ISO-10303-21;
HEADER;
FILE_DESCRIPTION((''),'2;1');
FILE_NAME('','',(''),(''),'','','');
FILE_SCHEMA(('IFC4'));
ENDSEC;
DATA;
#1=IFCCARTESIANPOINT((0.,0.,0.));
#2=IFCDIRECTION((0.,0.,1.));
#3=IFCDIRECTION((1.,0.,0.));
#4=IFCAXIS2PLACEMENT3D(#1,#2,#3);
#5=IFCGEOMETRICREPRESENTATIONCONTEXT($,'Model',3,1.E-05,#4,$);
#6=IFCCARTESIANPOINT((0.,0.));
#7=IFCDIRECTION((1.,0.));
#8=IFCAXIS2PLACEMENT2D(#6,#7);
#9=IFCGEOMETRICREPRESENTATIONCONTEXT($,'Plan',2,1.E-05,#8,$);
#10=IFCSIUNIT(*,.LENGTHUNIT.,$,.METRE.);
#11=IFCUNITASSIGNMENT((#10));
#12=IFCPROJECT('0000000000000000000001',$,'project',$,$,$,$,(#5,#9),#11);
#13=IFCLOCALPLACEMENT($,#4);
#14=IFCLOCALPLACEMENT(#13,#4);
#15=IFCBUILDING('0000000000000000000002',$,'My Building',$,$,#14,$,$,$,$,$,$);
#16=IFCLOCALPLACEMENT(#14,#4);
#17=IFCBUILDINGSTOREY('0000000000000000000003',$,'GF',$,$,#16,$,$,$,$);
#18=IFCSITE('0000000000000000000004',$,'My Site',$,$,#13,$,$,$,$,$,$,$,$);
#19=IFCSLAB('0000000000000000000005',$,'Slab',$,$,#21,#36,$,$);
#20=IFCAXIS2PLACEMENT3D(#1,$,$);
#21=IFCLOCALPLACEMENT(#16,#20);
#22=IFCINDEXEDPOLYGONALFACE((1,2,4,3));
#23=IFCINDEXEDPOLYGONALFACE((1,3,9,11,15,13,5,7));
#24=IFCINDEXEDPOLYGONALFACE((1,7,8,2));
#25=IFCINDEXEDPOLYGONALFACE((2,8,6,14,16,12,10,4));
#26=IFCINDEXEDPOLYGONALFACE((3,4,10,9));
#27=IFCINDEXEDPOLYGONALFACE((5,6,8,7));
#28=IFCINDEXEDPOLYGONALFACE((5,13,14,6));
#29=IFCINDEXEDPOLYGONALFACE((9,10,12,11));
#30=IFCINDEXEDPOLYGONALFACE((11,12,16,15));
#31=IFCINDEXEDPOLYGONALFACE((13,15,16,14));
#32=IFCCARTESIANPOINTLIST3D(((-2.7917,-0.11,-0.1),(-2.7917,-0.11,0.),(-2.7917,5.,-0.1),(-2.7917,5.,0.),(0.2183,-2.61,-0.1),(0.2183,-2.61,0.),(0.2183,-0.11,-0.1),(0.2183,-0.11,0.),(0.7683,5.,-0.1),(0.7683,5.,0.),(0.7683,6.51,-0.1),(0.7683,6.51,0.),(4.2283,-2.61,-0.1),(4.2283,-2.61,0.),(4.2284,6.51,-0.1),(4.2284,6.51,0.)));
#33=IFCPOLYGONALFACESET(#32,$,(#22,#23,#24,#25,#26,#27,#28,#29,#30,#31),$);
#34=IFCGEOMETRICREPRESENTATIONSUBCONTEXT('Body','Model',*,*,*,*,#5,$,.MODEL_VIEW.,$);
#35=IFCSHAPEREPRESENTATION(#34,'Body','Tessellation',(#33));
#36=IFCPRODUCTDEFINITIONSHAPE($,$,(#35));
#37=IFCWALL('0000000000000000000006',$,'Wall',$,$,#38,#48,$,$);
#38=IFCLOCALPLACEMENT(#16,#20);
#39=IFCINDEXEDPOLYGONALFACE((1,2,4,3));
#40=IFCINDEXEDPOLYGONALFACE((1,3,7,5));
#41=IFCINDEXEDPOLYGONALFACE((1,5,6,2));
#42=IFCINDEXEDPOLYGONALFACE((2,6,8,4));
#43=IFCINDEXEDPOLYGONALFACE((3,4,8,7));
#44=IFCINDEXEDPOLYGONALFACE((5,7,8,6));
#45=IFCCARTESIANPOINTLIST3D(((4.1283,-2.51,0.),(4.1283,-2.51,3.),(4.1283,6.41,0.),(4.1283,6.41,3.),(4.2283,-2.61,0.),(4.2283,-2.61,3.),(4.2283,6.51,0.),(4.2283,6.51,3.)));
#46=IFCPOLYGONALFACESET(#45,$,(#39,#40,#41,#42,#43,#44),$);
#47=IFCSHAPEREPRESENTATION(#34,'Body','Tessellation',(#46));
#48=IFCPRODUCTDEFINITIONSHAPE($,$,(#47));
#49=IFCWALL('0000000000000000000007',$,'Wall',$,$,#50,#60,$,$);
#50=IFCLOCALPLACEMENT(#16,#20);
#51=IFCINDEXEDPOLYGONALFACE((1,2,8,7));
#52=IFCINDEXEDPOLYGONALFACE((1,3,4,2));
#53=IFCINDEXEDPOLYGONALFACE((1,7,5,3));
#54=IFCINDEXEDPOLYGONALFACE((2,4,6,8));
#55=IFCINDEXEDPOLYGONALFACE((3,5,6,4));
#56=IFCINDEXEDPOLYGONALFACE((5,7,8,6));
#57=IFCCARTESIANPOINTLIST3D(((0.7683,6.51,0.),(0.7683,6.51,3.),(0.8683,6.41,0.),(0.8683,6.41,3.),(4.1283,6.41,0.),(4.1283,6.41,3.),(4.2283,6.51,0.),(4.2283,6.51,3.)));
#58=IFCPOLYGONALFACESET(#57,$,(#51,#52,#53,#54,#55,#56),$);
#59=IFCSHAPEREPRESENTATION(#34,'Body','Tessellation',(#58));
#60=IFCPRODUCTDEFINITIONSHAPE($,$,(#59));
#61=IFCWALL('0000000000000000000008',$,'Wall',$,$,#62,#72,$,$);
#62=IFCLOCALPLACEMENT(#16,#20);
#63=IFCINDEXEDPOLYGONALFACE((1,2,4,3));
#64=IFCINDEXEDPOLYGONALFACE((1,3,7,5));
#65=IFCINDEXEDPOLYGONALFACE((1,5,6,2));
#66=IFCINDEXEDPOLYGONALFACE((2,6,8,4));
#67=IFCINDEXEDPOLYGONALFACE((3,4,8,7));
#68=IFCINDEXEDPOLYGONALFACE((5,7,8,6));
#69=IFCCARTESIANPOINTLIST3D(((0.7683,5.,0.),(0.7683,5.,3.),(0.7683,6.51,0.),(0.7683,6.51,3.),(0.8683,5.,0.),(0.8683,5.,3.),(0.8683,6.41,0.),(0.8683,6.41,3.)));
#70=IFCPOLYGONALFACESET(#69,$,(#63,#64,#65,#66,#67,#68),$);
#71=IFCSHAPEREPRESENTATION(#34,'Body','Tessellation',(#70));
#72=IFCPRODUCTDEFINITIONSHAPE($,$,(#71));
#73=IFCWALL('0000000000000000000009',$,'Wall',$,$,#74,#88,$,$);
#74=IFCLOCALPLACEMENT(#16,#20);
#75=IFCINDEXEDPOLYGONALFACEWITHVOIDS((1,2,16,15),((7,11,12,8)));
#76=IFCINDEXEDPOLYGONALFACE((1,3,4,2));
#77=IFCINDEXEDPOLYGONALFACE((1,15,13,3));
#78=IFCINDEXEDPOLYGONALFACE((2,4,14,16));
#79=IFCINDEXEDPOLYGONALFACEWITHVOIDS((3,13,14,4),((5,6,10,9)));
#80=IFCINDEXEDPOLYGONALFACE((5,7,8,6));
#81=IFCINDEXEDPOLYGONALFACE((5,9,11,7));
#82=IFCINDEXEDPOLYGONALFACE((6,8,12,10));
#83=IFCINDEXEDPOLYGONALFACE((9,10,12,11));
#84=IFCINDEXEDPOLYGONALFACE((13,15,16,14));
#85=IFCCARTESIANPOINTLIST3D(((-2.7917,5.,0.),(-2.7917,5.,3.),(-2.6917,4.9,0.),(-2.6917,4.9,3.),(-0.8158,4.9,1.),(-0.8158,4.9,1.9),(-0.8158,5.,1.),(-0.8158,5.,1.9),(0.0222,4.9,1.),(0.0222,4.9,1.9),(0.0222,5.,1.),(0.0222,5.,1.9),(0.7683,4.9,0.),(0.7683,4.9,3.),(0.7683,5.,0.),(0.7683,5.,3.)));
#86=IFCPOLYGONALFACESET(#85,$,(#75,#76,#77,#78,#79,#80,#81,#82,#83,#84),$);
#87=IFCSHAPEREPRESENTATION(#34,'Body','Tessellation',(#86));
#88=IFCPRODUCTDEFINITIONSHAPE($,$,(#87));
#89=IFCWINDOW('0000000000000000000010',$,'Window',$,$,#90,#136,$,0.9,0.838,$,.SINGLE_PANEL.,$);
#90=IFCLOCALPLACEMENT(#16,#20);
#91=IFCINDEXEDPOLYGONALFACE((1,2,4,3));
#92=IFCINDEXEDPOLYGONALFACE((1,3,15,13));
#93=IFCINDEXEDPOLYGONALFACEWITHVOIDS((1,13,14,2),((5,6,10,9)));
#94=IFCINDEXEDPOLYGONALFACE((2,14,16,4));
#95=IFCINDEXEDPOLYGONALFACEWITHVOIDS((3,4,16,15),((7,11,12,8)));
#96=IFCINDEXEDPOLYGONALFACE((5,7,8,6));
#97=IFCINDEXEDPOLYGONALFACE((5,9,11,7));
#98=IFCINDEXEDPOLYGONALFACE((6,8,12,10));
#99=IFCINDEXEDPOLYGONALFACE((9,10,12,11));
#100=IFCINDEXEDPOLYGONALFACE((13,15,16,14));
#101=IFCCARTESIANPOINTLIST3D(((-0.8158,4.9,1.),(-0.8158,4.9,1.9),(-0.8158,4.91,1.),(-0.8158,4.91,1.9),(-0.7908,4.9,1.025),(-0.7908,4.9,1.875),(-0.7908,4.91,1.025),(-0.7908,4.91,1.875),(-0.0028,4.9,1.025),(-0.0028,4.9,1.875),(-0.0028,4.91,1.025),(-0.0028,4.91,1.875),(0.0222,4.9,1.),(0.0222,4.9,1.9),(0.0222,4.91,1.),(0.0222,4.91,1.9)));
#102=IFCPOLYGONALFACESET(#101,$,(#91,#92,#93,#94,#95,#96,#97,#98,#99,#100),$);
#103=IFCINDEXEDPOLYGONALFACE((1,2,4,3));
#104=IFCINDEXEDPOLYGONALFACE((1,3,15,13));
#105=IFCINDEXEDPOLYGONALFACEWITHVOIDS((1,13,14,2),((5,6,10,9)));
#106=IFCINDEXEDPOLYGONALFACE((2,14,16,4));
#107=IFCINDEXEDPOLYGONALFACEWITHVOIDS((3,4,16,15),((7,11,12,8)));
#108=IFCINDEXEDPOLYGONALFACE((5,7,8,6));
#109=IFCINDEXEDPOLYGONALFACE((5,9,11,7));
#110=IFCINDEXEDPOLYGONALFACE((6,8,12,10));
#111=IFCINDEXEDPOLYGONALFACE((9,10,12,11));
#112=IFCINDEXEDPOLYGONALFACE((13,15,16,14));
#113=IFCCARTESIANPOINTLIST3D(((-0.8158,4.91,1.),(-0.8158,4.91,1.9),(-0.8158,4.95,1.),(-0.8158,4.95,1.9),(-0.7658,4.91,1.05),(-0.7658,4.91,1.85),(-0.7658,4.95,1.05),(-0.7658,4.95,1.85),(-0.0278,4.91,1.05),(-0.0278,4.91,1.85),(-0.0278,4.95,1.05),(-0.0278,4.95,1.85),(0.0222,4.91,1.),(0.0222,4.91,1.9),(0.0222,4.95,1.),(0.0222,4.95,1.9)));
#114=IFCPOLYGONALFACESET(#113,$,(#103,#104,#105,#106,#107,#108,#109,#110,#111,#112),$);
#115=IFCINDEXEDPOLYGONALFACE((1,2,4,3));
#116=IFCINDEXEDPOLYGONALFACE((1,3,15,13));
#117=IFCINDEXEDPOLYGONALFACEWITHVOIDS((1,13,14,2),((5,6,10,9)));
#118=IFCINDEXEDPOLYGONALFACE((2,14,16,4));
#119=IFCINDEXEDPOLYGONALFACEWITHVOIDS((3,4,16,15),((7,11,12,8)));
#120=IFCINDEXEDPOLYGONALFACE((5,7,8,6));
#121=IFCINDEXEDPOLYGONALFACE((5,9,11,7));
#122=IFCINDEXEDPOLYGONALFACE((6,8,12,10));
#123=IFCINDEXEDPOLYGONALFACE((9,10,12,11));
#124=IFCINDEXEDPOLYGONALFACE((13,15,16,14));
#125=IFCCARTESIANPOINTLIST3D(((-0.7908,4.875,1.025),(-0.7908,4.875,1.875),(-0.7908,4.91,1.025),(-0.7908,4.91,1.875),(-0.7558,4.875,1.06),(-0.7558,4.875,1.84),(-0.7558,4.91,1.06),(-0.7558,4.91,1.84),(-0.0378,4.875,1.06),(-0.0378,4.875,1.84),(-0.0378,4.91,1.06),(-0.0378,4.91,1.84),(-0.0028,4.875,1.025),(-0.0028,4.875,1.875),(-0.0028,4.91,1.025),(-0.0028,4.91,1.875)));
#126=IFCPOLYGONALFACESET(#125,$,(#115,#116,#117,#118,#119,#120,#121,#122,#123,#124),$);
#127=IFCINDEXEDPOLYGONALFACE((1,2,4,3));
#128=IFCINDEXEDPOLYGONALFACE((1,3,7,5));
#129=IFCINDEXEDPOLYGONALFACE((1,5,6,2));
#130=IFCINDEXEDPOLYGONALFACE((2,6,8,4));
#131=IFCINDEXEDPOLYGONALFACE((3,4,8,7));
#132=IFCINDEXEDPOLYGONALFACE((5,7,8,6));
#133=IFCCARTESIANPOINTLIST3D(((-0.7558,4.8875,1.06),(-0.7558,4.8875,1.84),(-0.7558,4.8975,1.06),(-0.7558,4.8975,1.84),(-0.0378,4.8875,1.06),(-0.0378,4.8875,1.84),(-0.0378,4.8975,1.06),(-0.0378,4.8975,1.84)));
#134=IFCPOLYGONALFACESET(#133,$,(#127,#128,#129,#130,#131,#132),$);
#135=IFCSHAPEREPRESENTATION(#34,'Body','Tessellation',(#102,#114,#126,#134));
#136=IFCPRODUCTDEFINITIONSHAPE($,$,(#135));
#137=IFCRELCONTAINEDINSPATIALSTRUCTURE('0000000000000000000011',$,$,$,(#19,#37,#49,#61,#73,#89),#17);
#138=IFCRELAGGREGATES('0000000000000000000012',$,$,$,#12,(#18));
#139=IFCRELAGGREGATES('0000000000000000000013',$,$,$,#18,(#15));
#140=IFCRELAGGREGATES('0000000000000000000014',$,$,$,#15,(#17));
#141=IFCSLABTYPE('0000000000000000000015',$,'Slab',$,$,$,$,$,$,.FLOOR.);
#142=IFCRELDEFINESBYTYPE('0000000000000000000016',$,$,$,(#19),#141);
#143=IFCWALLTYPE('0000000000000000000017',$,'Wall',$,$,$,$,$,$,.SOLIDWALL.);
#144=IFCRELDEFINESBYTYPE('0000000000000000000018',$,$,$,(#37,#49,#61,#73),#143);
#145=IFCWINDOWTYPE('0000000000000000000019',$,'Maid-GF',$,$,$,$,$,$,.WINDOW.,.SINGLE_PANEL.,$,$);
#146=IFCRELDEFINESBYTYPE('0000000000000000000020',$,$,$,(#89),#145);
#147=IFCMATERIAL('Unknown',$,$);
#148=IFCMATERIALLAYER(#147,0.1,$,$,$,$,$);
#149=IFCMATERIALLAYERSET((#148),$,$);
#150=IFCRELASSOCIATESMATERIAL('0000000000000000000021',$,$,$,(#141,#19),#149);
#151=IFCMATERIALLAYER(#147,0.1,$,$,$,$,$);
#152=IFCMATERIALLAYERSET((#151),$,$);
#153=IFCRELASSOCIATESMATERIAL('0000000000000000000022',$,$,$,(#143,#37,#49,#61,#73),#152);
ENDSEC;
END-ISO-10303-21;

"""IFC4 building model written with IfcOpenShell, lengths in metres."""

from ifc_helpers import new_model, entity, si_unit, frame, origin_with_axes, origin_2d_with_axis, place, context, subcontext, project, spatial, line, indexed_curve, outline, extrude, shape, source, transform, mapped, material, layer, layer_set, layer_usage, type_object, type_shapes, element, fill, save


model = new_model("IFC4")

# Units and contexts
model_context = context("Model", 3, precision=1e-05, world=origin_with_axes())
plan_context = context("Plan", 2, precision=1e-05, world=origin_2d_with_axis())
body_context_1 = subcontext(model_context, "Body", "Model", "MODEL_VIEW")
body_context_2 = subcontext(plan_context, "Body", "Plan", "PLAN_VIEW")
ifc_project = project(units=[si_unit("LENGTHUNIT", "METRE")], contexts=[model_context, plan_context])

# Site, building, storey
site_placement = place(None, origin_with_axes())
site = spatial("IfcSite", under=ifc_project, at=site_placement, Name="My Site")
building_placement = place(site_placement, origin_with_axes())
building = spatial("IfcBuilding", under=site, at=building_placement, Name="My Building")
storey_placement = place(building_placement, origin_with_axes())
storey = spatial("IfcBuildingStorey", under=building, at=storey_placement, Name="GF")

# Slab
ifc_material = material(Name="Unknown")
ifc_layer_1 = layer(ifc_material, 0.1)
ifc_layer_set_1 = layer_set([ifc_layer_1])
ifc_layer_usage_1 = layer_usage(ifc_layer_set_1, "AXIS3", "POSITIVE", -0.1)
slab_type = type_object("IfcSlabType", Name="Slab", PredefinedType="FLOOR", material=ifc_layer_set_1)
slab_placement = place(storey_placement, frame((0.2183, -2.61, 0.0), z_axis=(0.0, 0.0, 1.0), x_axis=(1.0, 0.0, 0.0)))
element("IfcSlab", 1, at=slab_placement, inside=storey, type_object=slab_type, material=ifc_layer_usage_1, Name="Slab", context=body_context_1, shape_type="SweptSolid", body=[
    extrude(outline(indexed_curve([(4.01, 0.0), (4.01, 9.12), (0.55, 9.12), (0.55, 7.61), (-3.01, 7.61), (-3.01, 2.5), (0.0, 2.5), (0.0, 0.0), (4.01, 0.0)])), frame((0.0, 0.0, -0.1), z_axis=(0.0, 0.0, 1.0), x_axis=(1.0, 0.0, 0.0)), (0.0, 0.0, 1.0), 0.1),
])

# Shared definitions
ifc_layer_2 = layer(ifc_material, 0.1)
ifc_layer_set_2 = layer_set([ifc_layer_2])
wall_type = type_object("IfcWallType", Name="Wall", PredefinedType="SOLIDWALL", material=ifc_layer_set_2)

# Walls
ifc_layer_usage_2 = layer_usage(ifc_layer_set_2, "AXIS2", "POSITIVE", 0.0)
wall_1_placement = place(storey_placement, frame((4.2283, -2.61, 0.0), z_axis=(0.0, 0.0, 1.0), x_axis=(0.0, 1.0, 0.0)))
element("IfcWall", 2, at=wall_1_placement, inside=storey, type_object=wall_type, material=ifc_layer_usage_2, Name="Wall", context=body_context_1, shape_type="SweptSolid", body=[
    extrude(outline(indexed_curve([(0.0, 0.0), (0.1, 0.1), (9.02, 0.1), (9.12, 0.0)], segments=[line(1, 2, 3, 4, 1)])), origin_with_axes(), (0.0, 0.0, 1.0), 3.0),
])
ifc_layer_usage_3 = layer_usage(ifc_layer_set_2, "AXIS2", "POSITIVE", 0.0)
wall_2_placement = place(storey_placement, frame((4.2283, 6.51, 0.0), z_axis=(0.0, 0.0, 1.0), x_axis=(-1.0, 0.0, 0.0)))
element("IfcWall", 3, at=wall_2_placement, inside=storey, type_object=wall_type, material=ifc_layer_usage_3, Name="Wall", context=body_context_1, shape_type="SweptSolid", body=[
    extrude(outline(indexed_curve([(0.0, 0.0), (0.1, 0.1), (3.36, 0.1), (3.46, 0.0)], segments=[line(1, 2, 3, 4, 1)])), origin_with_axes(), (0.0, 0.0, 1.0), 3.0),
])
ifc_layer_usage_4 = layer_usage(ifc_layer_set_2, "AXIS2", "POSITIVE", 0.0)
wall_3_placement = place(storey_placement, frame((0.7683, 6.51, 0.0), z_axis=(0.0, 0.0, 1.0), x_axis=(0.0, -1.0, 0.0)))
element("IfcWall", 4, at=wall_3_placement, inside=storey, type_object=wall_type, material=ifc_layer_usage_4, Name="Wall", context=body_context_1, shape_type="SweptSolid", body=[
    extrude(outline(indexed_curve([(0.0, 0.0), (0.1, 0.1), (1.51, 0.1), (1.51, 0.0)], segments=[line(1, 2, 3, 4, 1)])), origin_with_axes(), (0.0, 0.0, 1.0), 3.0),
])

# Wall, opening, window
ifc_layer_usage_5 = layer_usage(ifc_layer_set_2, "AXIS2", "POSITIVE", 0.0)
wall_4_placement = place(storey_placement, frame((0.7683, 5.0, 0.0), z_axis=(0.0, 0.0, 1.0), x_axis=(-1.0, 0.0, 0.0)))
wall_4 = element("IfcWall", 5, at=wall_4_placement, inside=storey, type_object=wall_type, material=ifc_layer_usage_5, Name="Wall", context=body_context_1, shape_type="SweptSolid", body=[
    extrude(outline(indexed_curve([(0.0, 0.0), (0.0, 0.1), (3.46, 0.1), (3.56, 0.0)], segments=[line(1, 2, 3, 4, 1)])), origin_with_axes(), (0.0, 0.0, 1.0), 3.0),
])
shared_shape_1 = source(origin_with_axes(), body_context_1, "Body", "SweptSolid", [
    extrude(outline(indexed_curve([(0.0, 0.0), (0.838, 0.0), (0.838, 0.9), (0.0, 0.9)], segments=[line(1, 2, 3, 4, 1)])), frame((0.0, -0.6, 0.0), z_axis=(0.0, -1.0, 0.0), x_axis=(1.0, 0.0, 0.0)), (0.0, 0.0, -1.0), 1.2),
])
opening_1_placement = place(wall_4_placement, frame((0.7462, 0.0, 1.0), z_axis=(0.0, 0.0, 1.0), x_axis=(1.0, 0.0, 0.0)))
opening_1 = element("IfcOpeningElement", 6, at=opening_1_placement, cuts=wall_4, PredefinedType="OPENING", context=body_context_1, shape_type="MappedRepresentation", body=[
    mapped(shared_shape_1, transform((0.0, 0.0, 0.0), x_axis=(1.0, 0.0, 0.0), y_axis=(0.0, 1.0, 0.0), z_axis=(0.0, 0.0, 1.0), scale=1.0)),
])
window_type_1 = type_object("IfcWindowType", Name="Maid-GF", PartitioningType="SINGLE_PANEL", PredefinedType="WINDOW")
shared_shape_2 = source(origin_with_axes(), body_context_1, "Body", "SweptSolid", [
    extrude(outline(indexed_curve([(0.0, 0.0), (0.838, 0.0), (0.838, 0.9), (0.0, 0.9)], segments=[line(1, 2, 3, 4, 1)]), holes=[indexed_curve([(0.025, 0.025), (0.813, 0.025), (0.813, 0.875), (0.025, 0.875)], segments=[line(1, 2, 3, 4, 1)])]), frame((0.0, 0.09, 0.0), z_axis=(0.0, -1.0, 0.0), x_axis=(1.0, 0.0, 0.0)), (0.0, 0.0, -1.0), 0.01),
    extrude(outline(indexed_curve([(0.0, 0.0), (0.838, 0.0), (0.838, 0.9), (0.0, 0.9)], segments=[line(1, 2, 3, 4, 1)]), holes=[indexed_curve([(0.05, 0.05), (0.788, 0.05), (0.788, 0.85), (0.05, 0.85)], segments=[line(1, 2, 3, 4, 1)])]), frame((0.0, 0.05, 0.0), z_axis=(0.0, -1.0, 0.0), x_axis=(1.0, 0.0, 0.0)), (0.0, 0.0, -1.0), 0.04),
    extrude(outline(indexed_curve([(0.0, 0.0), (0.788, 0.0), (0.788, 0.85), (0.0, 0.85)], segments=[line(1, 2, 3, 4, 1)]), holes=[indexed_curve([(0.035, 0.035), (0.753, 0.035), (0.753, 0.815), (0.035, 0.815)], segments=[line(1, 2, 3, 4, 1)])]), frame((0.025, 0.09, 0.025), z_axis=(0.0, -1.0, 0.0), x_axis=(1.0, 0.0, 0.0)), (0.0, 0.0, -1.0), 0.035),
    extrude(outline(indexed_curve([(0.035, 0.035), (0.753, 0.035), (0.753, 0.815), (0.035, 0.815)], segments=[line(1, 2, 3, 4, 1)])), frame((0.025, 0.1025, 0.025), z_axis=(0.0, -1.0, 0.0), x_axis=(1.0, 0.0, 0.0)), (0.0, 0.0, -1.0), 0.01),
])
shared_shape_3 = source(origin_with_axes(), body_context_2, "Body", "Curve2D", [
    entity("IfcIndexedPolyCurve", entity("IfcCartesianPointList2D", [[0.05, 0.05], [0.788, 0.05]])),
    entity("IfcIndexedPolyCurve", entity("IfcCartesianPointList2D", [[0.0, 0.1], [0.025, 0.1], [0.025, 0.09], [0.05, 0.09], [0.05, 0.05], [0.0, 0.05]]), [entity("IfcLineIndex", [1, 2, 3, 4, 5, 6, 1])]),
    entity("IfcIndexedPolyCurve", entity("IfcCartesianPointList2D", [[0.838, 0.1], [0.813, 0.1], [0.813, 0.09], [0.788, 0.09], [0.788, 0.05], [0.838, 0.05]]), [entity("IfcLineIndex", [1, 2, 3, 4, 5, 6, 1])]),
    entity("IfcIndexedPolyCurve", entity("IfcCartesianPointList2D", [[0.025, 0.09], [0.06, 0.09], [0.06, 0.125], [0.025, 0.125]]), [entity("IfcLineIndex", [1, 2, 3, 4, 1])]),
    entity("IfcIndexedPolyCurve", entity("IfcCartesianPointList2D", [[0.813, 0.09], [0.778, 0.09], [0.778, 0.125], [0.813, 0.125]]), [entity("IfcLineIndex", [1, 2, 3, 4, 1])]),
    entity("IfcIndexedPolyCurve", entity("IfcCartesianPointList2D", [[0.06, 0.09], [0.778, 0.09]])),
    entity("IfcIndexedPolyCurve", entity("IfcCartesianPointList2D", [[0.06, 0.125], [0.778, 0.125]])),
    entity("IfcIndexedPolyCurve", entity("IfcCartesianPointList2D", [[0.06, 0.1075], [0.778, 0.1075]])),
])
type_shapes(window_type_1, [shared_shape_2, shared_shape_3])
window_1_placement = place(opening_1_placement, origin_with_axes())
window_1 = element("IfcWindow", 7, at=window_1_placement, inside=storey, type_object=window_type_1, Name="Window", OverallHeight=0.9, OverallWidth=0.838, PartitioningType="SINGLE_PANEL", shapes=[
    shape(body_context_1, "Body", "MappedRepresentation", [mapped(shared_shape_2, transform((0.0, 0.0, 0.0), x_axis=(1.0, 0.0, 0.0), y_axis=(0.0, 1.0, 0.0), z_axis=(0.0, 0.0, 1.0), scale=1.0))]),
    shape(body_context_2, "Body", "MappedRepresentation", [mapped(shared_shape_3, transform((0.0, 0.0, 0.0), x_axis=(1.0, 0.0, 0.0), y_axis=(0.0, 1.0, 0.0), z_axis=(0.0, 0.0, 1.0), scale=1.0))]),
])
fill(opening_1, window_1)

save(model, "model.ifc")
